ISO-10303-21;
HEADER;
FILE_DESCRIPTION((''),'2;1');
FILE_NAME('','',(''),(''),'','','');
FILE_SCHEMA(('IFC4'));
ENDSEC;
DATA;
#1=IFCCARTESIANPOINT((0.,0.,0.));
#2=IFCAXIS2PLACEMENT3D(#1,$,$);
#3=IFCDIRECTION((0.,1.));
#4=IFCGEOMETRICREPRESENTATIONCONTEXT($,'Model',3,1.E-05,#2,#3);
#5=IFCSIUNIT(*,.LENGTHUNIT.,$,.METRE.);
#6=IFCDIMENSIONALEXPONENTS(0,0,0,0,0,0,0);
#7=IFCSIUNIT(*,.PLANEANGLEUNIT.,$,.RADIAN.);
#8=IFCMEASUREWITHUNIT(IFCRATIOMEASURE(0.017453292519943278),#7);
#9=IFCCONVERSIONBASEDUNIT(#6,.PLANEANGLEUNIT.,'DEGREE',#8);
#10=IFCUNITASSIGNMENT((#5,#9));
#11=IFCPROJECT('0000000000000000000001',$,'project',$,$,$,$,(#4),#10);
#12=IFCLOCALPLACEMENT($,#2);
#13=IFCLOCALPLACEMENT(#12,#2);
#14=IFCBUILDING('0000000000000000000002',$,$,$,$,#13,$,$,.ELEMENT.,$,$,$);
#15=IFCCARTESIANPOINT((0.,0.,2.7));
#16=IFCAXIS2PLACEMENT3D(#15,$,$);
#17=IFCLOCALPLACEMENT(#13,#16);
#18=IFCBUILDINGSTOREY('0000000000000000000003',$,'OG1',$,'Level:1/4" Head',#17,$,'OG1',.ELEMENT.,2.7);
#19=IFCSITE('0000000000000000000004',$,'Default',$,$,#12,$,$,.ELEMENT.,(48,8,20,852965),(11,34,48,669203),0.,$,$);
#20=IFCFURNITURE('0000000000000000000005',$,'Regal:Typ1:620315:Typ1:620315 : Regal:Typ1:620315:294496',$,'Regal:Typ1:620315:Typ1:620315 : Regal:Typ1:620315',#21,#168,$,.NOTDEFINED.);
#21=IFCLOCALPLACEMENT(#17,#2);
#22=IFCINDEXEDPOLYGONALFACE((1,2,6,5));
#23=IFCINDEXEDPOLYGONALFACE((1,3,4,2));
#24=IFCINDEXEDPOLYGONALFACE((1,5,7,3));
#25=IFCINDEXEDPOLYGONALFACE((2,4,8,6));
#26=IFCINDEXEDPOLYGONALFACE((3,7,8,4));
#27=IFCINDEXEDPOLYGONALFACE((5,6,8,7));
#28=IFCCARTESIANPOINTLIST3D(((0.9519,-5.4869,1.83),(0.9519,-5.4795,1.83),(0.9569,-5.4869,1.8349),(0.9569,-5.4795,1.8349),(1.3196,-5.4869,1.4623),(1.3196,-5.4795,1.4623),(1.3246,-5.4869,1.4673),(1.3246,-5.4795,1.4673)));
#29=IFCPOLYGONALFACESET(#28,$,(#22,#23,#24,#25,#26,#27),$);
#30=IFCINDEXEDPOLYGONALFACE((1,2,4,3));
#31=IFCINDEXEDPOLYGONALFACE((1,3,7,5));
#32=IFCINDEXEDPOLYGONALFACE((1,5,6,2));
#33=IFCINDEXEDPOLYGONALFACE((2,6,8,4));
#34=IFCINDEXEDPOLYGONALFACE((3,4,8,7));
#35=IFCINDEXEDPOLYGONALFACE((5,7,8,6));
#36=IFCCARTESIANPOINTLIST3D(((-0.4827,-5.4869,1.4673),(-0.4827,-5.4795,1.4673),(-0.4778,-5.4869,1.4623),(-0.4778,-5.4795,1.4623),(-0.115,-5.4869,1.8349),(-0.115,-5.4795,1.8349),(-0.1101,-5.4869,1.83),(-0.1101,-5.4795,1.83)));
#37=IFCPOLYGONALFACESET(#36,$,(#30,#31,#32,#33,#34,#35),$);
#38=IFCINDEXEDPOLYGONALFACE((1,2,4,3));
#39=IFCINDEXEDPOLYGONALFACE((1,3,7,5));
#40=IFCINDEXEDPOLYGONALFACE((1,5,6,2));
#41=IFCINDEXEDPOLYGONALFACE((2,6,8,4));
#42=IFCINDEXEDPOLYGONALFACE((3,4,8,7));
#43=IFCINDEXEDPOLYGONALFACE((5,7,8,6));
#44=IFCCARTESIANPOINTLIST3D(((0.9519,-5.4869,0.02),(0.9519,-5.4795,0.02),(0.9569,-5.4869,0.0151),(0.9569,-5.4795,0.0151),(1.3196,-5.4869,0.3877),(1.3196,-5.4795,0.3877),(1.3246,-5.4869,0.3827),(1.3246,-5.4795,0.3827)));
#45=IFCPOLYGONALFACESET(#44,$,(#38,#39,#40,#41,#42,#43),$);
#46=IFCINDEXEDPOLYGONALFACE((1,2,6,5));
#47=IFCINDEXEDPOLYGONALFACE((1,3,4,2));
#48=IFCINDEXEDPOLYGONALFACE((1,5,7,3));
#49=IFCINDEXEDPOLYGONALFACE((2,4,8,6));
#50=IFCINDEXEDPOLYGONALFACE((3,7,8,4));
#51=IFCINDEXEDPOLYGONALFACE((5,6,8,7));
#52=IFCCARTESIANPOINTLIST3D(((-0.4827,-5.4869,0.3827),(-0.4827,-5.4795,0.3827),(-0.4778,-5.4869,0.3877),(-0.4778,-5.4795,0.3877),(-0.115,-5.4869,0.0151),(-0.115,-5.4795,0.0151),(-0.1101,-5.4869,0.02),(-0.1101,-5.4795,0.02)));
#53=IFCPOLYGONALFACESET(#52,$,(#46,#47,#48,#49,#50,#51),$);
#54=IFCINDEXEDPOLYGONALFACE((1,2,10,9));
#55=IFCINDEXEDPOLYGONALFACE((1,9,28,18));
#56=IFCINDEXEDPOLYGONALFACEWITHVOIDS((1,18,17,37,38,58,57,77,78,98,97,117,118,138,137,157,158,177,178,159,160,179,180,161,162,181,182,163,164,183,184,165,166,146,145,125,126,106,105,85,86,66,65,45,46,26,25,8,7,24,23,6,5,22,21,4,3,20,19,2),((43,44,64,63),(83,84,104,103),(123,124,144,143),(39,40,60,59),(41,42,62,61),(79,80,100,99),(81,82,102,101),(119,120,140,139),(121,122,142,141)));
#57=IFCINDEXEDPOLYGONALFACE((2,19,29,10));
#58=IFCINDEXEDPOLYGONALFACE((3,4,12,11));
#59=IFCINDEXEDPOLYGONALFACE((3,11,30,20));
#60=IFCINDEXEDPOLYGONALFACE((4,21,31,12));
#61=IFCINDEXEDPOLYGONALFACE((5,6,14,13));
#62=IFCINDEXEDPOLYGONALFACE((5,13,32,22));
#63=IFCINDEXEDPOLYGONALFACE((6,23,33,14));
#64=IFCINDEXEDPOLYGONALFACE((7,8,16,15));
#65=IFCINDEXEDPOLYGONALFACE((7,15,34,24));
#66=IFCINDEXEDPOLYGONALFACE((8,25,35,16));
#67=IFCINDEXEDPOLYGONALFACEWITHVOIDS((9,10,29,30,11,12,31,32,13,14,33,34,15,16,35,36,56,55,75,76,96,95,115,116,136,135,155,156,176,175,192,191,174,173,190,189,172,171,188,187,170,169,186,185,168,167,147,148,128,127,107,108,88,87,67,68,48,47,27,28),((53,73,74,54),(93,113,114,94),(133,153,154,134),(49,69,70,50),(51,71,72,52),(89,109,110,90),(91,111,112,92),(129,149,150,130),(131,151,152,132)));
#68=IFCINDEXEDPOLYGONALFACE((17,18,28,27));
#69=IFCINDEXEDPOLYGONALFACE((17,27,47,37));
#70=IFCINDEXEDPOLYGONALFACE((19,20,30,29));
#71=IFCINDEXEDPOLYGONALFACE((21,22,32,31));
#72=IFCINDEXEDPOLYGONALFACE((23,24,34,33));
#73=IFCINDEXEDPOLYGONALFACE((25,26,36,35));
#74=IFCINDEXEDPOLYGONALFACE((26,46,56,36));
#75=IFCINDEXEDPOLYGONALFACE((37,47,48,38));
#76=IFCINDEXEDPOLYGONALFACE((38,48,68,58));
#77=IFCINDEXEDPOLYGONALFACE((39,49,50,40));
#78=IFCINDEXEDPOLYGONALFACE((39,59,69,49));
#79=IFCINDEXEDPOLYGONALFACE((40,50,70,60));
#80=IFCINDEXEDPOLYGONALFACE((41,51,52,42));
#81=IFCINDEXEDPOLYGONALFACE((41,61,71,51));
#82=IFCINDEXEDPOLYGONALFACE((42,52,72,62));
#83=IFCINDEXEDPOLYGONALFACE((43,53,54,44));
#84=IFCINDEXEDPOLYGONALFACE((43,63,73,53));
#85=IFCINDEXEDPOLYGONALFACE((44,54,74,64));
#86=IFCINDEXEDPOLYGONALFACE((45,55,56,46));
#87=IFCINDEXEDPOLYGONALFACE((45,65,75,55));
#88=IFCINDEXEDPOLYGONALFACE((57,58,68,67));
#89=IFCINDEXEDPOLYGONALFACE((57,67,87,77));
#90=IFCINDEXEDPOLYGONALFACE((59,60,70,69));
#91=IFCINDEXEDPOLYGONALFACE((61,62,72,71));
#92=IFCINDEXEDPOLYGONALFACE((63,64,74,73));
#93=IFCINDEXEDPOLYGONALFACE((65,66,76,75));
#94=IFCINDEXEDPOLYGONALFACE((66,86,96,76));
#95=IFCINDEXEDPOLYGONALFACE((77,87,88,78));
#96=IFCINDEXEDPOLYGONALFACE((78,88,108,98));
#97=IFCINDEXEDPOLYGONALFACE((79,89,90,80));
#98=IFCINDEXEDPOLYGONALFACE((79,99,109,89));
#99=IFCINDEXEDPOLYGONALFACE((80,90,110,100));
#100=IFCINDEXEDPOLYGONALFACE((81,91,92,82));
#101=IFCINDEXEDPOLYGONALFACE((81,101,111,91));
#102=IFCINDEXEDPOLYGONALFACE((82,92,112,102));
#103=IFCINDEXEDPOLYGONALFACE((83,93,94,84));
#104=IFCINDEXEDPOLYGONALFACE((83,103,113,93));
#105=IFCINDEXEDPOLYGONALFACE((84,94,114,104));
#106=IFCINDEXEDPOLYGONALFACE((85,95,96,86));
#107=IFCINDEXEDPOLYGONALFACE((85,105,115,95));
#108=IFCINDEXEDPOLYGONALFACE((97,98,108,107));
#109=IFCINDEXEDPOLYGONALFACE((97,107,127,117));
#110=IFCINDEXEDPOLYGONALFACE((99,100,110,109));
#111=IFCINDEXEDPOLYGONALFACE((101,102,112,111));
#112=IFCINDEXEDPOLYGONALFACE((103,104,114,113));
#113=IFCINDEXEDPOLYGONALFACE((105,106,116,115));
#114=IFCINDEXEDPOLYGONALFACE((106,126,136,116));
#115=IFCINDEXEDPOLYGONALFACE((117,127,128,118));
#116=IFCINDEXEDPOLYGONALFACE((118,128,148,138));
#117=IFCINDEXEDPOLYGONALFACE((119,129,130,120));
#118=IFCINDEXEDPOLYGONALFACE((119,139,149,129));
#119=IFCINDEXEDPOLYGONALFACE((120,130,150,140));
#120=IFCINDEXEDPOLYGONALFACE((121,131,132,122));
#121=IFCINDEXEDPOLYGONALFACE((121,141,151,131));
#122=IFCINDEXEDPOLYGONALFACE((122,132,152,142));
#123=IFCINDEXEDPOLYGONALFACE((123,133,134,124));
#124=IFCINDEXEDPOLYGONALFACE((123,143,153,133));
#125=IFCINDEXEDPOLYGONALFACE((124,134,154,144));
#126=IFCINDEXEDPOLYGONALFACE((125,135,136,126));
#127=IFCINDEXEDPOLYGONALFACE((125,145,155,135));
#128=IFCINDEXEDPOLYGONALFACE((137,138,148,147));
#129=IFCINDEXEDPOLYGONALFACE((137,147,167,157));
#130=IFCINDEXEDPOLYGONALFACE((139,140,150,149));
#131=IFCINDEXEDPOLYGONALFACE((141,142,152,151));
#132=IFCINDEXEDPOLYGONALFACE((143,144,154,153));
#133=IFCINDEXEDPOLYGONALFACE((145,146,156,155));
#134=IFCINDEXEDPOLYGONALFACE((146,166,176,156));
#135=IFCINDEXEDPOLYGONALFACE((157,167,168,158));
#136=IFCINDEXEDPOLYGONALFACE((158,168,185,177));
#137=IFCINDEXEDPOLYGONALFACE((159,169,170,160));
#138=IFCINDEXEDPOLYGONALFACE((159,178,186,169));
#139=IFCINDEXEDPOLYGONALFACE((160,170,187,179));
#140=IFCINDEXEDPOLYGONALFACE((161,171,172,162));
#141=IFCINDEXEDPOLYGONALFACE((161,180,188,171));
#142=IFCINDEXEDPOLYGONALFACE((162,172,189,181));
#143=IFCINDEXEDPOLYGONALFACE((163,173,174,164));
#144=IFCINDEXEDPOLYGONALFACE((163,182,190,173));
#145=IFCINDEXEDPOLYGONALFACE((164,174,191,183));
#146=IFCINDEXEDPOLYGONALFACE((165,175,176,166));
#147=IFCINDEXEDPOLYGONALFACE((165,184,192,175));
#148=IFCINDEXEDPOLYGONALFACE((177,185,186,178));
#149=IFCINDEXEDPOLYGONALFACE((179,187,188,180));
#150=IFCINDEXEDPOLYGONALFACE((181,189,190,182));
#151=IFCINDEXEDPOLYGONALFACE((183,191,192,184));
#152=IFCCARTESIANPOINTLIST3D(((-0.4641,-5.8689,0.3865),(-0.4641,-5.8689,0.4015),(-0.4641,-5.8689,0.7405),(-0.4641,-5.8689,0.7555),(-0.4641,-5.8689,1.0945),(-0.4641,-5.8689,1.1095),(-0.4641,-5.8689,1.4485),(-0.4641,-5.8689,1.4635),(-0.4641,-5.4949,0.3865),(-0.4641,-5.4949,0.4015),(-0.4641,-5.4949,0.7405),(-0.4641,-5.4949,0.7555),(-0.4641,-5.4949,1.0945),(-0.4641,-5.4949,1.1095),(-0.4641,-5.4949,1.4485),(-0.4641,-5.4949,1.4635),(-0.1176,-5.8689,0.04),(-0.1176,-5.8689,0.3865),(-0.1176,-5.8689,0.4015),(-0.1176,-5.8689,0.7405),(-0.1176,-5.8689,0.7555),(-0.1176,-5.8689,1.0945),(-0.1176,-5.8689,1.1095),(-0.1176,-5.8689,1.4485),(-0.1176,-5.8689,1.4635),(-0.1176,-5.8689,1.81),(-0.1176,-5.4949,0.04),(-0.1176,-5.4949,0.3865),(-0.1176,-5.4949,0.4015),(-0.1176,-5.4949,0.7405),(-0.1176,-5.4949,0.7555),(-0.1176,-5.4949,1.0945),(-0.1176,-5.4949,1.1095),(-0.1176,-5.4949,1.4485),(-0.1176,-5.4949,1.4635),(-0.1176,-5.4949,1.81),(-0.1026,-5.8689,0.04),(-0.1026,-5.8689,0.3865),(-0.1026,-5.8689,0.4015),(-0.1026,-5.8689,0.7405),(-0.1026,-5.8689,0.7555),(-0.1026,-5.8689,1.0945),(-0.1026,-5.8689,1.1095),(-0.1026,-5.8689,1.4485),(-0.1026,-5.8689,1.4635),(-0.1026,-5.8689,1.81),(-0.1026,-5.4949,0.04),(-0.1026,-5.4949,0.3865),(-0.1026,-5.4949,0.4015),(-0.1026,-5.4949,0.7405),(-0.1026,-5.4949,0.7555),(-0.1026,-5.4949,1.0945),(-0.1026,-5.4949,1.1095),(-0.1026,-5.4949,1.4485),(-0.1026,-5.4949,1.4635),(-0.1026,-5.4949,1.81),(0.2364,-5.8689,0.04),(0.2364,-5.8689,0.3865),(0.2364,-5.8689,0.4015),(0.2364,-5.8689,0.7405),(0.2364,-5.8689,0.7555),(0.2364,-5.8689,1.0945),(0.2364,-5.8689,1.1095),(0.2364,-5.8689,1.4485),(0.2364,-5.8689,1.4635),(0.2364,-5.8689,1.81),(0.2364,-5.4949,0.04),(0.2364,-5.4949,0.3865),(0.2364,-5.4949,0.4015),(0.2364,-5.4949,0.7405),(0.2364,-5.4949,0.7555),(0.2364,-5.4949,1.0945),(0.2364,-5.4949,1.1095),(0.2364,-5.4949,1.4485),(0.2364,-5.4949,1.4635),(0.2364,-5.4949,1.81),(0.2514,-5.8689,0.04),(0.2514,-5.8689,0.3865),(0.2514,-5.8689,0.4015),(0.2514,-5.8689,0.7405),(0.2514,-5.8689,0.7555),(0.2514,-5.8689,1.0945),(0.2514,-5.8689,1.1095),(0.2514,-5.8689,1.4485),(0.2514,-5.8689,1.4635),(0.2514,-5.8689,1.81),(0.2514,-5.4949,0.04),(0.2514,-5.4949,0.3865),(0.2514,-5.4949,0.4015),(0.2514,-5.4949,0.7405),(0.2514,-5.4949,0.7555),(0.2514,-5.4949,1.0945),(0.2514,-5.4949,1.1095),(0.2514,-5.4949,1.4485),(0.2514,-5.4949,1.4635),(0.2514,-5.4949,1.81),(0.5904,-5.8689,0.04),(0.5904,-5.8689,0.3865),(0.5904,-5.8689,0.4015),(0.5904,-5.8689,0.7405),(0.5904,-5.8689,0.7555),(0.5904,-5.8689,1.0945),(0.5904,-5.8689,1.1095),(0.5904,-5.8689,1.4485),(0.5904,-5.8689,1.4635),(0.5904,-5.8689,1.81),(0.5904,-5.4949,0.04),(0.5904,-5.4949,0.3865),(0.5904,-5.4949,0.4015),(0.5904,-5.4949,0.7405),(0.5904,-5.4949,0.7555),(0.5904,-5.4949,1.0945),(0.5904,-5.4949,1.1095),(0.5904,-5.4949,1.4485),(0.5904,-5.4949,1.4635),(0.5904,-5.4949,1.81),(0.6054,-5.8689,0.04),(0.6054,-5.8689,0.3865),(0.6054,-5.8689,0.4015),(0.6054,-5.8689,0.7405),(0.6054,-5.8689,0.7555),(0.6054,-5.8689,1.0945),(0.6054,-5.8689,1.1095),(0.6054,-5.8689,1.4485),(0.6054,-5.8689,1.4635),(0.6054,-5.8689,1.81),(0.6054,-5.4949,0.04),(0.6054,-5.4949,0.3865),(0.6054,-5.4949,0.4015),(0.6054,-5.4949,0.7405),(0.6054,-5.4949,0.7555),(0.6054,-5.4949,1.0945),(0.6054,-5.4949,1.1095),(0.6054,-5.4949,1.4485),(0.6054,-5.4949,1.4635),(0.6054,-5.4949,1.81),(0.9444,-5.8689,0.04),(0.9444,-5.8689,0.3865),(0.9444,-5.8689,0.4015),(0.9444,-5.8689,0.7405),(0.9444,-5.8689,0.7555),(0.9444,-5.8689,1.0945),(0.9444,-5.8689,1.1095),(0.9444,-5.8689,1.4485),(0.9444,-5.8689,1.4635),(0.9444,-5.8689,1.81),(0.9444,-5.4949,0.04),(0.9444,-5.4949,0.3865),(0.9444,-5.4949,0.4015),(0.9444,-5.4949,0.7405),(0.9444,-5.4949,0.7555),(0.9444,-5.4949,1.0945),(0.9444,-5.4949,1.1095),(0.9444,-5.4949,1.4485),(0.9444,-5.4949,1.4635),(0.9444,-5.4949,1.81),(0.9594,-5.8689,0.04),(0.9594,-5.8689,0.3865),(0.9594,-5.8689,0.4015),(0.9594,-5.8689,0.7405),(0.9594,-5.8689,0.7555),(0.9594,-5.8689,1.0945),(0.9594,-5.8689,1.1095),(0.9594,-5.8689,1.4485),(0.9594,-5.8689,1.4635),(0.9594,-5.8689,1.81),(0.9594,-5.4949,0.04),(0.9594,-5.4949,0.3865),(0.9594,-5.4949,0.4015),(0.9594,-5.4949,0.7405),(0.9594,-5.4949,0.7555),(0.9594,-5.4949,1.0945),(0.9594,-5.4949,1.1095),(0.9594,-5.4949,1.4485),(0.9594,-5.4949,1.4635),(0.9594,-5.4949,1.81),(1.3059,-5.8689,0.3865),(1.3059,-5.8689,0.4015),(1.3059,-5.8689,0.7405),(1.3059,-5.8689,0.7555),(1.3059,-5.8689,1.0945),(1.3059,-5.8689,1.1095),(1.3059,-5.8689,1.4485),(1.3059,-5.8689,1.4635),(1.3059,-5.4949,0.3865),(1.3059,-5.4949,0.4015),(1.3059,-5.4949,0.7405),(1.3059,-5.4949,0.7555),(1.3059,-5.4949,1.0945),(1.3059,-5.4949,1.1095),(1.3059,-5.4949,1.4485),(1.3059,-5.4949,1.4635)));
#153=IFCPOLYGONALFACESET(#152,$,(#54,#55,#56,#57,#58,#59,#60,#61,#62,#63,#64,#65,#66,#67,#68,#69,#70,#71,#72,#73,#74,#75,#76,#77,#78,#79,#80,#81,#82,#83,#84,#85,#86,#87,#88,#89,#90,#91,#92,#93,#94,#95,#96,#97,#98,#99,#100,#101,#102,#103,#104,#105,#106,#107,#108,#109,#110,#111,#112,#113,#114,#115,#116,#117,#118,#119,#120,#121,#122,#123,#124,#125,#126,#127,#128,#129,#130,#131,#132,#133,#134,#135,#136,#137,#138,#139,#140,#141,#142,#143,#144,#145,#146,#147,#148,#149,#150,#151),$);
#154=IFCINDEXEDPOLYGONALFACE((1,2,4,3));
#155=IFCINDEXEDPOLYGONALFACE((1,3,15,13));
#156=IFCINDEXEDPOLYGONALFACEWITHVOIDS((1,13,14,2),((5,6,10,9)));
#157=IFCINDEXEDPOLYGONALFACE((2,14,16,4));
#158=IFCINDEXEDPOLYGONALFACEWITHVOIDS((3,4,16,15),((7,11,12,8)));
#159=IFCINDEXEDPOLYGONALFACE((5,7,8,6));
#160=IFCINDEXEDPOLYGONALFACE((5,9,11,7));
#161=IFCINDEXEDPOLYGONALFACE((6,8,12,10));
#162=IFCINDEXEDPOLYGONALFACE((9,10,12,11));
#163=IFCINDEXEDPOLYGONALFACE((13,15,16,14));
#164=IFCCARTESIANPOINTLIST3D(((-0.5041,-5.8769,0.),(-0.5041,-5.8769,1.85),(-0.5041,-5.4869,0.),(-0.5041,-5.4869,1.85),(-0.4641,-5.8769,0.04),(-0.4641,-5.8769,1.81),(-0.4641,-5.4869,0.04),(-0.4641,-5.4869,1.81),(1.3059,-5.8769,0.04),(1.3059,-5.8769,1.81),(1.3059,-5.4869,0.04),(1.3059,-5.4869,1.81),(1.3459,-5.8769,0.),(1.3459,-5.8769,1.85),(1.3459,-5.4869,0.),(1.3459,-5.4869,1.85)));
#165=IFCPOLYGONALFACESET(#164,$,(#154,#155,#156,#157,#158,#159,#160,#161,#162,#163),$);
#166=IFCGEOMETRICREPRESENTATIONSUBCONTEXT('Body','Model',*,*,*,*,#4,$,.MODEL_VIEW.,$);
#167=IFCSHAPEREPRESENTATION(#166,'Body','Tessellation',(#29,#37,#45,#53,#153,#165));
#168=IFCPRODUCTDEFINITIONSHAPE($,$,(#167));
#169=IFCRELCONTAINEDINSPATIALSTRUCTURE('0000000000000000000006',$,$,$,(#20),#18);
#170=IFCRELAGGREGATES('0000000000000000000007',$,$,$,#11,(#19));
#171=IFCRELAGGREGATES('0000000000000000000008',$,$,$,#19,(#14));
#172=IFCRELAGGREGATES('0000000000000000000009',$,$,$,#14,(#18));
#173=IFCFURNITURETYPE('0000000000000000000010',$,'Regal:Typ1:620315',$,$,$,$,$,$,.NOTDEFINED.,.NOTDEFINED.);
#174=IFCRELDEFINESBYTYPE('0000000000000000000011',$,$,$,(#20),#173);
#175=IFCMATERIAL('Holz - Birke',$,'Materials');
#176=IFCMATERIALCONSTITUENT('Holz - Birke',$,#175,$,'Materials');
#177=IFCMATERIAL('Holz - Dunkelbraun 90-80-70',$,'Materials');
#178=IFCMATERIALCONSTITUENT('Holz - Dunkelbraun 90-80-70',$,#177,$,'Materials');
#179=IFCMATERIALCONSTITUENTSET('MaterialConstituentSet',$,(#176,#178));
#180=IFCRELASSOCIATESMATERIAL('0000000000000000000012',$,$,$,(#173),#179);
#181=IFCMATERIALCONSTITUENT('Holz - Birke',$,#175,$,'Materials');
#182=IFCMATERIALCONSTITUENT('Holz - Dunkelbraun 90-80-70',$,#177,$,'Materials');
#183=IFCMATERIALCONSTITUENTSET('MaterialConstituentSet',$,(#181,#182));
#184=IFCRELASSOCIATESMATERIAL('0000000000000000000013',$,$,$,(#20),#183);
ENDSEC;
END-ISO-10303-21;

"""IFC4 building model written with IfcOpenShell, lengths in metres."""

from ifc_helpers import new_model, entity, si_unit, converted_unit, direction, frame, origin, place, context, subcontext, project, spatial, indexed_curve, outline, extrude, source, transform, mapped, material, constituent, constituent_set, type_object, type_shapes, element, save


model = new_model("IFC4")

# Units and contexts
model_context = context("Model", 3, precision=1e-05, world=origin(), true_north=direction((0.0, 1.0)))
body_context = subcontext(model_context, "Body", "Model", "MODEL_VIEW")
ifc_project = project(units=[si_unit("LENGTHUNIT", "METRE"), converted_unit("PLANEANGLEUNIT", "DEGREE", entity("IfcRatioMeasure", 0.017453292519943278), si_unit("PLANEANGLEUNIT", "RADIAN"), dimensions=[0, 0, 0, 0, 0, 0, 0])], contexts=[model_context])

# Site, building, storey
site_placement = place(None, origin())
site = spatial("IfcSite", under=ifc_project, at=site_placement, Name="Default", CompositionType="ELEMENT", RefLatitude=(48, 8, 20, 852965), RefLongitude=(11, 34, 48, 669203), RefElevation=0.0)
building_placement = place(site_placement, origin())
building = spatial("IfcBuilding", under=site, at=building_placement, CompositionType="ELEMENT")
storey_placement = place(building_placement, frame((0.0, 0.0, 2.7)))
storey = spatial("IfcBuildingStorey", under=building, at=storey_placement, Name="OG1", ObjectType="Level:1/4\" Head", LongName="OG1", CompositionType="ELEMENT", Elevation=2.7)

# Shared definitions
ifc_material_1 = material(Name="Holz - Birke", Category="Materials")

# Furniture
ifc_material_2 = material(Name="Holz - Dunkelbraun 90-80-70", Category="Materials")
ifc_constituent_1 = constituent(ifc_material_1, Name="Holz - Birke", Category="Materials")
ifc_constituent_2 = constituent(ifc_material_2, Name="Holz - Dunkelbraun 90-80-70", Category="Materials")
ifc_constituent_set_1 = constituent_set(constituents=[ifc_constituent_1, ifc_constituent_2], Name="MaterialConstituentSet")
ifc_constituent_3 = constituent(ifc_material_1, Name="Holz - Birke", Category="Materials")
ifc_constituent_4 = constituent(ifc_material_2, Name="Holz - Dunkelbraun 90-80-70", Category="Materials")
ifc_constituent_set_2 = constituent_set(constituents=[ifc_constituent_3, ifc_constituent_4], Name="MaterialConstituentSet")
furniture_type_1 = type_object("IfcFurnitureType", Name="Regal:Typ1:620315", AssemblyPlace="NOTDEFINED", PredefinedType="NOTDEFINED", material=ifc_constituent_set_2)
shared_shape_1 = source(origin(), body_context, "Body", "SweptSolid", [
    extrude(outline(indexed_curve([(-0.0035, -0.0037), (0.0035, -0.0037), (0.0035, 0.0037), (-0.0035, 0.0037), (-0.0035, -0.0037)], self_intersect=False)), frame((1.3221, -5.4832, 4.1648), z_axis=(-0.707107, 0.0, 0.707107), x_axis=(-0.707107, 0.0, -0.707107)), (0.0, 0.0, 1.0), 0.52),
    extrude(outline(indexed_curve([(-0.0035, -0.0037), (0.0035, -0.0037), (0.0035, 0.0037), (-0.0035, 0.0037), (-0.0035, -0.0037)], self_intersect=False)), frame((-0.4802, -5.4832, 4.1648), z_axis=(0.707107, 0.0, 0.707107), x_axis=(-0.707107, 0.0, 0.707107)), (0.0, 0.0, 1.0), 0.52),
    extrude(outline(indexed_curve([(-0.0035, -0.0037), (0.0035, -0.0037), (0.0035, 0.0037), (-0.0035, 0.0037), (-0.0035, -0.0037)], self_intersect=False)), frame((0.9544, -5.4832, 2.7175), z_axis=(0.707107, 0.0, 0.707107), x_axis=(-0.707107, 0.0, 0.707107)), (0.0, 0.0, 1.0), 0.52),
    extrude(outline(indexed_curve([(-0.0035, -0.0037), (0.0035, -0.0037), (0.0035, 0.0037), (-0.0035, 0.0037), (-0.0035, -0.0037)], self_intersect=False)), frame((-0.1125, -5.4832, 2.7175), z_axis=(-0.707107, 0.0, 0.707107), x_axis=(-0.707107, 0.0, -0.707107)), (0.0, 0.0, 1.0), 0.52),
    extrude(outline(indexed_curve([(-0.5385, -0.885), (-0.5235, -0.885), (-0.5235, -0.5385), (-0.1845, -0.5385), (-0.1845, -0.885), (-0.1695, -0.885), (-0.1695, -0.5385), (0.1695, -0.5385), (0.1695, -0.885), (0.1845, -0.885), (0.1845, -0.5385), (0.5235, -0.5385), (0.5235, -0.885), (0.5385, -0.885), (0.5385, -0.5385), (0.885, -0.5385), (0.885, -0.5235), (0.5385, -0.5235), (0.5385, -0.1845), (0.885, -0.1845), (0.885, -0.1695), (0.5385, -0.1695), (0.5385, 0.1695), (0.885, 0.1695), (0.885, 0.1845), (0.5385, 0.1845), (0.5385, 0.5235), (0.885, 0.5235), (0.885, 0.5385), (0.5385, 0.5385), (0.5385, 0.885), (0.5235, 0.885), (0.5235, 0.5385), (0.1845, 0.5385), (0.1845, 0.885), (0.1695, 0.885), (0.1695, 0.5385), (-0.1695, 0.5385), (-0.1695, 0.885), (-0.1845, 0.885), (-0.1845, 0.5385), (-0.5235, 0.5385), (-0.5235, 0.885), (-0.5385, 0.885), (-0.5385, 0.5385), (-0.885, 0.5385), (-0.885, 0.5235), (-0.5385, 0.5235), (-0.5385, 0.1845), (-0.885, 0.1845), (-0.885, 0.1695), (-0.5385, 0.1695), (-0.5385, -0.1695), (-0.885, -0.1695), (-0.885, -0.1845), (-0.5385, -0.1845), (-0.5385, -0.5235), (-0.885, -0.5235), (-0.885, -0.5385), (-0.5385, -0.5385), (-0.5385, -0.885)], self_intersect=False), holes=[indexed_curve([(-0.5235, -0.5235), (-0.5235, -0.1845), (-0.1845, -0.1845), (-0.1845, -0.5235), (-0.5235, -0.5235)], self_intersect=False), indexed_curve([(0.1695, -0.1845), (0.1695, -0.5235), (-0.1695, -0.5235), (-0.1695, -0.1845), (0.1695, -0.1845)], self_intersect=False), indexed_curve([(0.5235, -0.1845), (0.5235, -0.5235), (0.1845, -0.5235), (0.1845, -0.1845), (0.5235, -0.1845)], self_intersect=False), indexed_curve([(0.5235, -0.1695), (0.1845, -0.1695), (0.1845, 0.1695), (0.5235, 0.1695), (0.5235, -0.1695)], self_intersect=False), indexed_curve([(0.1695, -0.1695), (-0.1695, -0.1695), (-0.1695, 0.1695), (0.1695, 0.1695), (0.1695, -0.1695)], self_intersect=False), indexed_curve([(-0.1845, -0.1695), (-0.5235, -0.1695), (-0.5235, 0.1695), (-0.1845, 0.1695), (-0.1845, -0.1695)], self_intersect=False), indexed_curve([(-0.1845, 0.5235), (-0.1845, 0.1845), (-0.5235, 0.1845), (-0.5235, 0.5235), (-0.1845, 0.5235)], self_intersect=False), indexed_curve([(0.1695, 0.5235), (0.1695, 0.1845), (-0.1695, 0.1845), (-0.1695, 0.5235), (0.1695, 0.5235)], self_intersect=False), indexed_curve([(0.5235, 0.5235), (0.5235, 0.1845), (0.1845, 0.1845), (0.1845, 0.5235), (0.5235, 0.5235)], self_intersect=False)]), frame((0.4209, -5.8689, 3.625), z_axis=(0.0, 1.0, 0.0), x_axis=(1.0, 0.0, 0.0)), (0.0, 0.0, 1.0), 0.374),
    extrude(outline(indexed_curve([(-0.925, -0.925), (0.925, -0.925), (0.925, 0.925), (-0.925, 0.925), (-0.925, -0.925)], self_intersect=False), holes=[indexed_curve([(0.885, 0.885), (0.885, -0.885), (-0.885, -0.885), (-0.885, 0.885), (0.885, 0.885)], self_intersect=False)]), frame((0.4209, -5.8769, 3.625), z_axis=(0.0, 1.0, 0.0), x_axis=(-1.0, 0.0, 0.0)), (0.0, 0.0, 1.0), 0.39),
])
type_shapes(furniture_type_1, [shared_shape_1])
furniture_1_placement = place(storey_placement, frame((0.0, 0.0, -2.7)))
element("IfcFurniture", 1, at=furniture_1_placement, inside=storey, type_object=furniture_type_1, material=ifc_constituent_set_1, Name="Regal:Typ1:620315:Typ1:620315 : Regal:Typ1:620315:294496", ObjectType="Regal:Typ1:620315:Typ1:620315 : Regal:Typ1:620315", PredefinedType="NOTDEFINED", context=body_context, shape_type="MappedRepresentation", body=[
    mapped(shared_shape_1, transform((0.0, 0.0, 0.0), scale=1.0)),
])

save(model, "model.ifc")
